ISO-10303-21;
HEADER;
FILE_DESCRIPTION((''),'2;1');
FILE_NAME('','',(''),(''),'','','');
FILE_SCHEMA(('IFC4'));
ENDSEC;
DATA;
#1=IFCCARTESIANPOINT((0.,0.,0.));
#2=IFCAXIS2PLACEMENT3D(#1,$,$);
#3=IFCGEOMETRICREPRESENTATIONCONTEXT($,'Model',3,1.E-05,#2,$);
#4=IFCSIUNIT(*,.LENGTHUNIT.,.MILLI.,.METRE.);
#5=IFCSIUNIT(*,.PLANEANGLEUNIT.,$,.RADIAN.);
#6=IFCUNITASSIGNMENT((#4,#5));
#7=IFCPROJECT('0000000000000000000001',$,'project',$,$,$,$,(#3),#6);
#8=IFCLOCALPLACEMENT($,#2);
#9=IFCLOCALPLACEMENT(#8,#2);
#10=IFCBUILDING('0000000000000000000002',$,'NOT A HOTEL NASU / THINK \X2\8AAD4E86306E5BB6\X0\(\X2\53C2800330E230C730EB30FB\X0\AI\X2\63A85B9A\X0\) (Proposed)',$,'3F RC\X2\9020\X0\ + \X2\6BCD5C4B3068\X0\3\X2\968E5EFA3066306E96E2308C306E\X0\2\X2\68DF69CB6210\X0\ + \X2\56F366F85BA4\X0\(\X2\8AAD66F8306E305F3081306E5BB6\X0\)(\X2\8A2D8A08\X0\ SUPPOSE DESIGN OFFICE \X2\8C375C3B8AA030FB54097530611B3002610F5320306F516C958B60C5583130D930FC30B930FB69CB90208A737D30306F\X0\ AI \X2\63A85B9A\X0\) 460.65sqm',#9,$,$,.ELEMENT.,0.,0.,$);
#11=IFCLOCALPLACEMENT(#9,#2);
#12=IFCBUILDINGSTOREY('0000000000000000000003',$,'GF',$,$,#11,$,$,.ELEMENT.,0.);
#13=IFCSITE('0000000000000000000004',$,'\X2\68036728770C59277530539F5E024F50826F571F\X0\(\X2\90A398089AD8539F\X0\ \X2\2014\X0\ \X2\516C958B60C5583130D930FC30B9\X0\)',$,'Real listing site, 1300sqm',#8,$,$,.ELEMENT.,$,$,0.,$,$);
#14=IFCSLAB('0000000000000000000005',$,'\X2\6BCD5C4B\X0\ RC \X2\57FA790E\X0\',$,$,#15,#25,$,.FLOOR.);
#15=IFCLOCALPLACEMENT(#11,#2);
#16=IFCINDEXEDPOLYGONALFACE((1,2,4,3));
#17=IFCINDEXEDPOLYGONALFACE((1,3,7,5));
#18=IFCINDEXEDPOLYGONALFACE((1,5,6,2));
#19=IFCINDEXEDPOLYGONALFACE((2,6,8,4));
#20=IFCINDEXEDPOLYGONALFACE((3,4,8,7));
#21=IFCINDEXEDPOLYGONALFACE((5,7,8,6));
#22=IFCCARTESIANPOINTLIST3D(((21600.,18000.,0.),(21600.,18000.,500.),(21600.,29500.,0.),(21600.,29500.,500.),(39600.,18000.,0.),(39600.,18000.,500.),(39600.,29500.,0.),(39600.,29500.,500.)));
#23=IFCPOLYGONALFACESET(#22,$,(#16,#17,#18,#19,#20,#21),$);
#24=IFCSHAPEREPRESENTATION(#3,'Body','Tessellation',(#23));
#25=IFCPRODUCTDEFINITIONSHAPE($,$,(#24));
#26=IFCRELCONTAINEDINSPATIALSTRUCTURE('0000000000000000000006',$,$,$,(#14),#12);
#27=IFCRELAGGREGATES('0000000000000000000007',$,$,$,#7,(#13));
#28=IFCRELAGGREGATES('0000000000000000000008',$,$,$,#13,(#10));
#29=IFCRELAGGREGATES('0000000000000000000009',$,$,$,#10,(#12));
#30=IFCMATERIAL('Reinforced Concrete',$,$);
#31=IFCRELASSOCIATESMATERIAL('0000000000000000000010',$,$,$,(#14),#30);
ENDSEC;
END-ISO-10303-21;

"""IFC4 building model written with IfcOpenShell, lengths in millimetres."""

from ifc_helpers import new_model, si_unit, frame, frame_2d, origin, place, context, project, spatial, rectangle, extrude, material, element, save


model = new_model("IFC4")

# Units and contexts
model_context = context("Model", 3, precision=1e-05, world=origin())
ifc_project = project(units=[si_unit("LENGTHUNIT", "METRE", prefix="MILLI"), si_unit("PLANEANGLEUNIT", "RADIAN")], contexts=[model_context])

# Site, building, storey
site_placement = place(None, origin())
site = spatial("IfcSite", under=ifc_project, at=site_placement, Name="栃木県大田原市佐良土(那須高原 — 公開情報ベース)", ObjectType="Real listing site, 1300sqm", CompositionType="ELEMENT", RefElevation=0.0)
building_placement = place(site_placement, origin())
building = spatial("IfcBuilding", under=site, at=building_placement, Name="NOT A HOTEL NASU / THINK 読了の家(参考モデル・AI推定) (Proposed)", ObjectType="3F RC造 + 母屋と3階建ての離れの2棟構成 + 図書室(読書のための家)(設計 SUPPOSE DESIGN OFFICE 谷尻誠・吉田愛。意匠は公開情報ベース・構造詳細は AI 推定) 460.65sqm", CompositionType="ELEMENT", ElevationOfRefHeight=0.0, ElevationOfTerrain=0.0)
storey_placement = place(building_placement, origin())
storey = spatial("IfcBuildingStorey", under=building, at=storey_placement, Name="GF", CompositionType="ELEMENT", Elevation=0.0)

# Shared definitions
ifc_material_1 = material(Name="Reinforced Concrete")

# Slab
slab_1_placement = place(storey_placement, frame((10800.0, 9000.0, 0.0)))
element("IfcSlab", 1, at=slab_1_placement, inside=storey, material=ifc_material_1, Name="母屋 RC 基礎", PredefinedType="FLOOR", context=model_context, shape_type="SweptSolid", body=[
    extrude(rectangle(XDim=18000.0, YDim=11500.0, at=frame_2d((9000.0, 5750.0))), frame((10800.0, 9000.0, 0.0)), (0.0, 0.0, 1.0), 500.0),
])

save(model, "model.ifc")
